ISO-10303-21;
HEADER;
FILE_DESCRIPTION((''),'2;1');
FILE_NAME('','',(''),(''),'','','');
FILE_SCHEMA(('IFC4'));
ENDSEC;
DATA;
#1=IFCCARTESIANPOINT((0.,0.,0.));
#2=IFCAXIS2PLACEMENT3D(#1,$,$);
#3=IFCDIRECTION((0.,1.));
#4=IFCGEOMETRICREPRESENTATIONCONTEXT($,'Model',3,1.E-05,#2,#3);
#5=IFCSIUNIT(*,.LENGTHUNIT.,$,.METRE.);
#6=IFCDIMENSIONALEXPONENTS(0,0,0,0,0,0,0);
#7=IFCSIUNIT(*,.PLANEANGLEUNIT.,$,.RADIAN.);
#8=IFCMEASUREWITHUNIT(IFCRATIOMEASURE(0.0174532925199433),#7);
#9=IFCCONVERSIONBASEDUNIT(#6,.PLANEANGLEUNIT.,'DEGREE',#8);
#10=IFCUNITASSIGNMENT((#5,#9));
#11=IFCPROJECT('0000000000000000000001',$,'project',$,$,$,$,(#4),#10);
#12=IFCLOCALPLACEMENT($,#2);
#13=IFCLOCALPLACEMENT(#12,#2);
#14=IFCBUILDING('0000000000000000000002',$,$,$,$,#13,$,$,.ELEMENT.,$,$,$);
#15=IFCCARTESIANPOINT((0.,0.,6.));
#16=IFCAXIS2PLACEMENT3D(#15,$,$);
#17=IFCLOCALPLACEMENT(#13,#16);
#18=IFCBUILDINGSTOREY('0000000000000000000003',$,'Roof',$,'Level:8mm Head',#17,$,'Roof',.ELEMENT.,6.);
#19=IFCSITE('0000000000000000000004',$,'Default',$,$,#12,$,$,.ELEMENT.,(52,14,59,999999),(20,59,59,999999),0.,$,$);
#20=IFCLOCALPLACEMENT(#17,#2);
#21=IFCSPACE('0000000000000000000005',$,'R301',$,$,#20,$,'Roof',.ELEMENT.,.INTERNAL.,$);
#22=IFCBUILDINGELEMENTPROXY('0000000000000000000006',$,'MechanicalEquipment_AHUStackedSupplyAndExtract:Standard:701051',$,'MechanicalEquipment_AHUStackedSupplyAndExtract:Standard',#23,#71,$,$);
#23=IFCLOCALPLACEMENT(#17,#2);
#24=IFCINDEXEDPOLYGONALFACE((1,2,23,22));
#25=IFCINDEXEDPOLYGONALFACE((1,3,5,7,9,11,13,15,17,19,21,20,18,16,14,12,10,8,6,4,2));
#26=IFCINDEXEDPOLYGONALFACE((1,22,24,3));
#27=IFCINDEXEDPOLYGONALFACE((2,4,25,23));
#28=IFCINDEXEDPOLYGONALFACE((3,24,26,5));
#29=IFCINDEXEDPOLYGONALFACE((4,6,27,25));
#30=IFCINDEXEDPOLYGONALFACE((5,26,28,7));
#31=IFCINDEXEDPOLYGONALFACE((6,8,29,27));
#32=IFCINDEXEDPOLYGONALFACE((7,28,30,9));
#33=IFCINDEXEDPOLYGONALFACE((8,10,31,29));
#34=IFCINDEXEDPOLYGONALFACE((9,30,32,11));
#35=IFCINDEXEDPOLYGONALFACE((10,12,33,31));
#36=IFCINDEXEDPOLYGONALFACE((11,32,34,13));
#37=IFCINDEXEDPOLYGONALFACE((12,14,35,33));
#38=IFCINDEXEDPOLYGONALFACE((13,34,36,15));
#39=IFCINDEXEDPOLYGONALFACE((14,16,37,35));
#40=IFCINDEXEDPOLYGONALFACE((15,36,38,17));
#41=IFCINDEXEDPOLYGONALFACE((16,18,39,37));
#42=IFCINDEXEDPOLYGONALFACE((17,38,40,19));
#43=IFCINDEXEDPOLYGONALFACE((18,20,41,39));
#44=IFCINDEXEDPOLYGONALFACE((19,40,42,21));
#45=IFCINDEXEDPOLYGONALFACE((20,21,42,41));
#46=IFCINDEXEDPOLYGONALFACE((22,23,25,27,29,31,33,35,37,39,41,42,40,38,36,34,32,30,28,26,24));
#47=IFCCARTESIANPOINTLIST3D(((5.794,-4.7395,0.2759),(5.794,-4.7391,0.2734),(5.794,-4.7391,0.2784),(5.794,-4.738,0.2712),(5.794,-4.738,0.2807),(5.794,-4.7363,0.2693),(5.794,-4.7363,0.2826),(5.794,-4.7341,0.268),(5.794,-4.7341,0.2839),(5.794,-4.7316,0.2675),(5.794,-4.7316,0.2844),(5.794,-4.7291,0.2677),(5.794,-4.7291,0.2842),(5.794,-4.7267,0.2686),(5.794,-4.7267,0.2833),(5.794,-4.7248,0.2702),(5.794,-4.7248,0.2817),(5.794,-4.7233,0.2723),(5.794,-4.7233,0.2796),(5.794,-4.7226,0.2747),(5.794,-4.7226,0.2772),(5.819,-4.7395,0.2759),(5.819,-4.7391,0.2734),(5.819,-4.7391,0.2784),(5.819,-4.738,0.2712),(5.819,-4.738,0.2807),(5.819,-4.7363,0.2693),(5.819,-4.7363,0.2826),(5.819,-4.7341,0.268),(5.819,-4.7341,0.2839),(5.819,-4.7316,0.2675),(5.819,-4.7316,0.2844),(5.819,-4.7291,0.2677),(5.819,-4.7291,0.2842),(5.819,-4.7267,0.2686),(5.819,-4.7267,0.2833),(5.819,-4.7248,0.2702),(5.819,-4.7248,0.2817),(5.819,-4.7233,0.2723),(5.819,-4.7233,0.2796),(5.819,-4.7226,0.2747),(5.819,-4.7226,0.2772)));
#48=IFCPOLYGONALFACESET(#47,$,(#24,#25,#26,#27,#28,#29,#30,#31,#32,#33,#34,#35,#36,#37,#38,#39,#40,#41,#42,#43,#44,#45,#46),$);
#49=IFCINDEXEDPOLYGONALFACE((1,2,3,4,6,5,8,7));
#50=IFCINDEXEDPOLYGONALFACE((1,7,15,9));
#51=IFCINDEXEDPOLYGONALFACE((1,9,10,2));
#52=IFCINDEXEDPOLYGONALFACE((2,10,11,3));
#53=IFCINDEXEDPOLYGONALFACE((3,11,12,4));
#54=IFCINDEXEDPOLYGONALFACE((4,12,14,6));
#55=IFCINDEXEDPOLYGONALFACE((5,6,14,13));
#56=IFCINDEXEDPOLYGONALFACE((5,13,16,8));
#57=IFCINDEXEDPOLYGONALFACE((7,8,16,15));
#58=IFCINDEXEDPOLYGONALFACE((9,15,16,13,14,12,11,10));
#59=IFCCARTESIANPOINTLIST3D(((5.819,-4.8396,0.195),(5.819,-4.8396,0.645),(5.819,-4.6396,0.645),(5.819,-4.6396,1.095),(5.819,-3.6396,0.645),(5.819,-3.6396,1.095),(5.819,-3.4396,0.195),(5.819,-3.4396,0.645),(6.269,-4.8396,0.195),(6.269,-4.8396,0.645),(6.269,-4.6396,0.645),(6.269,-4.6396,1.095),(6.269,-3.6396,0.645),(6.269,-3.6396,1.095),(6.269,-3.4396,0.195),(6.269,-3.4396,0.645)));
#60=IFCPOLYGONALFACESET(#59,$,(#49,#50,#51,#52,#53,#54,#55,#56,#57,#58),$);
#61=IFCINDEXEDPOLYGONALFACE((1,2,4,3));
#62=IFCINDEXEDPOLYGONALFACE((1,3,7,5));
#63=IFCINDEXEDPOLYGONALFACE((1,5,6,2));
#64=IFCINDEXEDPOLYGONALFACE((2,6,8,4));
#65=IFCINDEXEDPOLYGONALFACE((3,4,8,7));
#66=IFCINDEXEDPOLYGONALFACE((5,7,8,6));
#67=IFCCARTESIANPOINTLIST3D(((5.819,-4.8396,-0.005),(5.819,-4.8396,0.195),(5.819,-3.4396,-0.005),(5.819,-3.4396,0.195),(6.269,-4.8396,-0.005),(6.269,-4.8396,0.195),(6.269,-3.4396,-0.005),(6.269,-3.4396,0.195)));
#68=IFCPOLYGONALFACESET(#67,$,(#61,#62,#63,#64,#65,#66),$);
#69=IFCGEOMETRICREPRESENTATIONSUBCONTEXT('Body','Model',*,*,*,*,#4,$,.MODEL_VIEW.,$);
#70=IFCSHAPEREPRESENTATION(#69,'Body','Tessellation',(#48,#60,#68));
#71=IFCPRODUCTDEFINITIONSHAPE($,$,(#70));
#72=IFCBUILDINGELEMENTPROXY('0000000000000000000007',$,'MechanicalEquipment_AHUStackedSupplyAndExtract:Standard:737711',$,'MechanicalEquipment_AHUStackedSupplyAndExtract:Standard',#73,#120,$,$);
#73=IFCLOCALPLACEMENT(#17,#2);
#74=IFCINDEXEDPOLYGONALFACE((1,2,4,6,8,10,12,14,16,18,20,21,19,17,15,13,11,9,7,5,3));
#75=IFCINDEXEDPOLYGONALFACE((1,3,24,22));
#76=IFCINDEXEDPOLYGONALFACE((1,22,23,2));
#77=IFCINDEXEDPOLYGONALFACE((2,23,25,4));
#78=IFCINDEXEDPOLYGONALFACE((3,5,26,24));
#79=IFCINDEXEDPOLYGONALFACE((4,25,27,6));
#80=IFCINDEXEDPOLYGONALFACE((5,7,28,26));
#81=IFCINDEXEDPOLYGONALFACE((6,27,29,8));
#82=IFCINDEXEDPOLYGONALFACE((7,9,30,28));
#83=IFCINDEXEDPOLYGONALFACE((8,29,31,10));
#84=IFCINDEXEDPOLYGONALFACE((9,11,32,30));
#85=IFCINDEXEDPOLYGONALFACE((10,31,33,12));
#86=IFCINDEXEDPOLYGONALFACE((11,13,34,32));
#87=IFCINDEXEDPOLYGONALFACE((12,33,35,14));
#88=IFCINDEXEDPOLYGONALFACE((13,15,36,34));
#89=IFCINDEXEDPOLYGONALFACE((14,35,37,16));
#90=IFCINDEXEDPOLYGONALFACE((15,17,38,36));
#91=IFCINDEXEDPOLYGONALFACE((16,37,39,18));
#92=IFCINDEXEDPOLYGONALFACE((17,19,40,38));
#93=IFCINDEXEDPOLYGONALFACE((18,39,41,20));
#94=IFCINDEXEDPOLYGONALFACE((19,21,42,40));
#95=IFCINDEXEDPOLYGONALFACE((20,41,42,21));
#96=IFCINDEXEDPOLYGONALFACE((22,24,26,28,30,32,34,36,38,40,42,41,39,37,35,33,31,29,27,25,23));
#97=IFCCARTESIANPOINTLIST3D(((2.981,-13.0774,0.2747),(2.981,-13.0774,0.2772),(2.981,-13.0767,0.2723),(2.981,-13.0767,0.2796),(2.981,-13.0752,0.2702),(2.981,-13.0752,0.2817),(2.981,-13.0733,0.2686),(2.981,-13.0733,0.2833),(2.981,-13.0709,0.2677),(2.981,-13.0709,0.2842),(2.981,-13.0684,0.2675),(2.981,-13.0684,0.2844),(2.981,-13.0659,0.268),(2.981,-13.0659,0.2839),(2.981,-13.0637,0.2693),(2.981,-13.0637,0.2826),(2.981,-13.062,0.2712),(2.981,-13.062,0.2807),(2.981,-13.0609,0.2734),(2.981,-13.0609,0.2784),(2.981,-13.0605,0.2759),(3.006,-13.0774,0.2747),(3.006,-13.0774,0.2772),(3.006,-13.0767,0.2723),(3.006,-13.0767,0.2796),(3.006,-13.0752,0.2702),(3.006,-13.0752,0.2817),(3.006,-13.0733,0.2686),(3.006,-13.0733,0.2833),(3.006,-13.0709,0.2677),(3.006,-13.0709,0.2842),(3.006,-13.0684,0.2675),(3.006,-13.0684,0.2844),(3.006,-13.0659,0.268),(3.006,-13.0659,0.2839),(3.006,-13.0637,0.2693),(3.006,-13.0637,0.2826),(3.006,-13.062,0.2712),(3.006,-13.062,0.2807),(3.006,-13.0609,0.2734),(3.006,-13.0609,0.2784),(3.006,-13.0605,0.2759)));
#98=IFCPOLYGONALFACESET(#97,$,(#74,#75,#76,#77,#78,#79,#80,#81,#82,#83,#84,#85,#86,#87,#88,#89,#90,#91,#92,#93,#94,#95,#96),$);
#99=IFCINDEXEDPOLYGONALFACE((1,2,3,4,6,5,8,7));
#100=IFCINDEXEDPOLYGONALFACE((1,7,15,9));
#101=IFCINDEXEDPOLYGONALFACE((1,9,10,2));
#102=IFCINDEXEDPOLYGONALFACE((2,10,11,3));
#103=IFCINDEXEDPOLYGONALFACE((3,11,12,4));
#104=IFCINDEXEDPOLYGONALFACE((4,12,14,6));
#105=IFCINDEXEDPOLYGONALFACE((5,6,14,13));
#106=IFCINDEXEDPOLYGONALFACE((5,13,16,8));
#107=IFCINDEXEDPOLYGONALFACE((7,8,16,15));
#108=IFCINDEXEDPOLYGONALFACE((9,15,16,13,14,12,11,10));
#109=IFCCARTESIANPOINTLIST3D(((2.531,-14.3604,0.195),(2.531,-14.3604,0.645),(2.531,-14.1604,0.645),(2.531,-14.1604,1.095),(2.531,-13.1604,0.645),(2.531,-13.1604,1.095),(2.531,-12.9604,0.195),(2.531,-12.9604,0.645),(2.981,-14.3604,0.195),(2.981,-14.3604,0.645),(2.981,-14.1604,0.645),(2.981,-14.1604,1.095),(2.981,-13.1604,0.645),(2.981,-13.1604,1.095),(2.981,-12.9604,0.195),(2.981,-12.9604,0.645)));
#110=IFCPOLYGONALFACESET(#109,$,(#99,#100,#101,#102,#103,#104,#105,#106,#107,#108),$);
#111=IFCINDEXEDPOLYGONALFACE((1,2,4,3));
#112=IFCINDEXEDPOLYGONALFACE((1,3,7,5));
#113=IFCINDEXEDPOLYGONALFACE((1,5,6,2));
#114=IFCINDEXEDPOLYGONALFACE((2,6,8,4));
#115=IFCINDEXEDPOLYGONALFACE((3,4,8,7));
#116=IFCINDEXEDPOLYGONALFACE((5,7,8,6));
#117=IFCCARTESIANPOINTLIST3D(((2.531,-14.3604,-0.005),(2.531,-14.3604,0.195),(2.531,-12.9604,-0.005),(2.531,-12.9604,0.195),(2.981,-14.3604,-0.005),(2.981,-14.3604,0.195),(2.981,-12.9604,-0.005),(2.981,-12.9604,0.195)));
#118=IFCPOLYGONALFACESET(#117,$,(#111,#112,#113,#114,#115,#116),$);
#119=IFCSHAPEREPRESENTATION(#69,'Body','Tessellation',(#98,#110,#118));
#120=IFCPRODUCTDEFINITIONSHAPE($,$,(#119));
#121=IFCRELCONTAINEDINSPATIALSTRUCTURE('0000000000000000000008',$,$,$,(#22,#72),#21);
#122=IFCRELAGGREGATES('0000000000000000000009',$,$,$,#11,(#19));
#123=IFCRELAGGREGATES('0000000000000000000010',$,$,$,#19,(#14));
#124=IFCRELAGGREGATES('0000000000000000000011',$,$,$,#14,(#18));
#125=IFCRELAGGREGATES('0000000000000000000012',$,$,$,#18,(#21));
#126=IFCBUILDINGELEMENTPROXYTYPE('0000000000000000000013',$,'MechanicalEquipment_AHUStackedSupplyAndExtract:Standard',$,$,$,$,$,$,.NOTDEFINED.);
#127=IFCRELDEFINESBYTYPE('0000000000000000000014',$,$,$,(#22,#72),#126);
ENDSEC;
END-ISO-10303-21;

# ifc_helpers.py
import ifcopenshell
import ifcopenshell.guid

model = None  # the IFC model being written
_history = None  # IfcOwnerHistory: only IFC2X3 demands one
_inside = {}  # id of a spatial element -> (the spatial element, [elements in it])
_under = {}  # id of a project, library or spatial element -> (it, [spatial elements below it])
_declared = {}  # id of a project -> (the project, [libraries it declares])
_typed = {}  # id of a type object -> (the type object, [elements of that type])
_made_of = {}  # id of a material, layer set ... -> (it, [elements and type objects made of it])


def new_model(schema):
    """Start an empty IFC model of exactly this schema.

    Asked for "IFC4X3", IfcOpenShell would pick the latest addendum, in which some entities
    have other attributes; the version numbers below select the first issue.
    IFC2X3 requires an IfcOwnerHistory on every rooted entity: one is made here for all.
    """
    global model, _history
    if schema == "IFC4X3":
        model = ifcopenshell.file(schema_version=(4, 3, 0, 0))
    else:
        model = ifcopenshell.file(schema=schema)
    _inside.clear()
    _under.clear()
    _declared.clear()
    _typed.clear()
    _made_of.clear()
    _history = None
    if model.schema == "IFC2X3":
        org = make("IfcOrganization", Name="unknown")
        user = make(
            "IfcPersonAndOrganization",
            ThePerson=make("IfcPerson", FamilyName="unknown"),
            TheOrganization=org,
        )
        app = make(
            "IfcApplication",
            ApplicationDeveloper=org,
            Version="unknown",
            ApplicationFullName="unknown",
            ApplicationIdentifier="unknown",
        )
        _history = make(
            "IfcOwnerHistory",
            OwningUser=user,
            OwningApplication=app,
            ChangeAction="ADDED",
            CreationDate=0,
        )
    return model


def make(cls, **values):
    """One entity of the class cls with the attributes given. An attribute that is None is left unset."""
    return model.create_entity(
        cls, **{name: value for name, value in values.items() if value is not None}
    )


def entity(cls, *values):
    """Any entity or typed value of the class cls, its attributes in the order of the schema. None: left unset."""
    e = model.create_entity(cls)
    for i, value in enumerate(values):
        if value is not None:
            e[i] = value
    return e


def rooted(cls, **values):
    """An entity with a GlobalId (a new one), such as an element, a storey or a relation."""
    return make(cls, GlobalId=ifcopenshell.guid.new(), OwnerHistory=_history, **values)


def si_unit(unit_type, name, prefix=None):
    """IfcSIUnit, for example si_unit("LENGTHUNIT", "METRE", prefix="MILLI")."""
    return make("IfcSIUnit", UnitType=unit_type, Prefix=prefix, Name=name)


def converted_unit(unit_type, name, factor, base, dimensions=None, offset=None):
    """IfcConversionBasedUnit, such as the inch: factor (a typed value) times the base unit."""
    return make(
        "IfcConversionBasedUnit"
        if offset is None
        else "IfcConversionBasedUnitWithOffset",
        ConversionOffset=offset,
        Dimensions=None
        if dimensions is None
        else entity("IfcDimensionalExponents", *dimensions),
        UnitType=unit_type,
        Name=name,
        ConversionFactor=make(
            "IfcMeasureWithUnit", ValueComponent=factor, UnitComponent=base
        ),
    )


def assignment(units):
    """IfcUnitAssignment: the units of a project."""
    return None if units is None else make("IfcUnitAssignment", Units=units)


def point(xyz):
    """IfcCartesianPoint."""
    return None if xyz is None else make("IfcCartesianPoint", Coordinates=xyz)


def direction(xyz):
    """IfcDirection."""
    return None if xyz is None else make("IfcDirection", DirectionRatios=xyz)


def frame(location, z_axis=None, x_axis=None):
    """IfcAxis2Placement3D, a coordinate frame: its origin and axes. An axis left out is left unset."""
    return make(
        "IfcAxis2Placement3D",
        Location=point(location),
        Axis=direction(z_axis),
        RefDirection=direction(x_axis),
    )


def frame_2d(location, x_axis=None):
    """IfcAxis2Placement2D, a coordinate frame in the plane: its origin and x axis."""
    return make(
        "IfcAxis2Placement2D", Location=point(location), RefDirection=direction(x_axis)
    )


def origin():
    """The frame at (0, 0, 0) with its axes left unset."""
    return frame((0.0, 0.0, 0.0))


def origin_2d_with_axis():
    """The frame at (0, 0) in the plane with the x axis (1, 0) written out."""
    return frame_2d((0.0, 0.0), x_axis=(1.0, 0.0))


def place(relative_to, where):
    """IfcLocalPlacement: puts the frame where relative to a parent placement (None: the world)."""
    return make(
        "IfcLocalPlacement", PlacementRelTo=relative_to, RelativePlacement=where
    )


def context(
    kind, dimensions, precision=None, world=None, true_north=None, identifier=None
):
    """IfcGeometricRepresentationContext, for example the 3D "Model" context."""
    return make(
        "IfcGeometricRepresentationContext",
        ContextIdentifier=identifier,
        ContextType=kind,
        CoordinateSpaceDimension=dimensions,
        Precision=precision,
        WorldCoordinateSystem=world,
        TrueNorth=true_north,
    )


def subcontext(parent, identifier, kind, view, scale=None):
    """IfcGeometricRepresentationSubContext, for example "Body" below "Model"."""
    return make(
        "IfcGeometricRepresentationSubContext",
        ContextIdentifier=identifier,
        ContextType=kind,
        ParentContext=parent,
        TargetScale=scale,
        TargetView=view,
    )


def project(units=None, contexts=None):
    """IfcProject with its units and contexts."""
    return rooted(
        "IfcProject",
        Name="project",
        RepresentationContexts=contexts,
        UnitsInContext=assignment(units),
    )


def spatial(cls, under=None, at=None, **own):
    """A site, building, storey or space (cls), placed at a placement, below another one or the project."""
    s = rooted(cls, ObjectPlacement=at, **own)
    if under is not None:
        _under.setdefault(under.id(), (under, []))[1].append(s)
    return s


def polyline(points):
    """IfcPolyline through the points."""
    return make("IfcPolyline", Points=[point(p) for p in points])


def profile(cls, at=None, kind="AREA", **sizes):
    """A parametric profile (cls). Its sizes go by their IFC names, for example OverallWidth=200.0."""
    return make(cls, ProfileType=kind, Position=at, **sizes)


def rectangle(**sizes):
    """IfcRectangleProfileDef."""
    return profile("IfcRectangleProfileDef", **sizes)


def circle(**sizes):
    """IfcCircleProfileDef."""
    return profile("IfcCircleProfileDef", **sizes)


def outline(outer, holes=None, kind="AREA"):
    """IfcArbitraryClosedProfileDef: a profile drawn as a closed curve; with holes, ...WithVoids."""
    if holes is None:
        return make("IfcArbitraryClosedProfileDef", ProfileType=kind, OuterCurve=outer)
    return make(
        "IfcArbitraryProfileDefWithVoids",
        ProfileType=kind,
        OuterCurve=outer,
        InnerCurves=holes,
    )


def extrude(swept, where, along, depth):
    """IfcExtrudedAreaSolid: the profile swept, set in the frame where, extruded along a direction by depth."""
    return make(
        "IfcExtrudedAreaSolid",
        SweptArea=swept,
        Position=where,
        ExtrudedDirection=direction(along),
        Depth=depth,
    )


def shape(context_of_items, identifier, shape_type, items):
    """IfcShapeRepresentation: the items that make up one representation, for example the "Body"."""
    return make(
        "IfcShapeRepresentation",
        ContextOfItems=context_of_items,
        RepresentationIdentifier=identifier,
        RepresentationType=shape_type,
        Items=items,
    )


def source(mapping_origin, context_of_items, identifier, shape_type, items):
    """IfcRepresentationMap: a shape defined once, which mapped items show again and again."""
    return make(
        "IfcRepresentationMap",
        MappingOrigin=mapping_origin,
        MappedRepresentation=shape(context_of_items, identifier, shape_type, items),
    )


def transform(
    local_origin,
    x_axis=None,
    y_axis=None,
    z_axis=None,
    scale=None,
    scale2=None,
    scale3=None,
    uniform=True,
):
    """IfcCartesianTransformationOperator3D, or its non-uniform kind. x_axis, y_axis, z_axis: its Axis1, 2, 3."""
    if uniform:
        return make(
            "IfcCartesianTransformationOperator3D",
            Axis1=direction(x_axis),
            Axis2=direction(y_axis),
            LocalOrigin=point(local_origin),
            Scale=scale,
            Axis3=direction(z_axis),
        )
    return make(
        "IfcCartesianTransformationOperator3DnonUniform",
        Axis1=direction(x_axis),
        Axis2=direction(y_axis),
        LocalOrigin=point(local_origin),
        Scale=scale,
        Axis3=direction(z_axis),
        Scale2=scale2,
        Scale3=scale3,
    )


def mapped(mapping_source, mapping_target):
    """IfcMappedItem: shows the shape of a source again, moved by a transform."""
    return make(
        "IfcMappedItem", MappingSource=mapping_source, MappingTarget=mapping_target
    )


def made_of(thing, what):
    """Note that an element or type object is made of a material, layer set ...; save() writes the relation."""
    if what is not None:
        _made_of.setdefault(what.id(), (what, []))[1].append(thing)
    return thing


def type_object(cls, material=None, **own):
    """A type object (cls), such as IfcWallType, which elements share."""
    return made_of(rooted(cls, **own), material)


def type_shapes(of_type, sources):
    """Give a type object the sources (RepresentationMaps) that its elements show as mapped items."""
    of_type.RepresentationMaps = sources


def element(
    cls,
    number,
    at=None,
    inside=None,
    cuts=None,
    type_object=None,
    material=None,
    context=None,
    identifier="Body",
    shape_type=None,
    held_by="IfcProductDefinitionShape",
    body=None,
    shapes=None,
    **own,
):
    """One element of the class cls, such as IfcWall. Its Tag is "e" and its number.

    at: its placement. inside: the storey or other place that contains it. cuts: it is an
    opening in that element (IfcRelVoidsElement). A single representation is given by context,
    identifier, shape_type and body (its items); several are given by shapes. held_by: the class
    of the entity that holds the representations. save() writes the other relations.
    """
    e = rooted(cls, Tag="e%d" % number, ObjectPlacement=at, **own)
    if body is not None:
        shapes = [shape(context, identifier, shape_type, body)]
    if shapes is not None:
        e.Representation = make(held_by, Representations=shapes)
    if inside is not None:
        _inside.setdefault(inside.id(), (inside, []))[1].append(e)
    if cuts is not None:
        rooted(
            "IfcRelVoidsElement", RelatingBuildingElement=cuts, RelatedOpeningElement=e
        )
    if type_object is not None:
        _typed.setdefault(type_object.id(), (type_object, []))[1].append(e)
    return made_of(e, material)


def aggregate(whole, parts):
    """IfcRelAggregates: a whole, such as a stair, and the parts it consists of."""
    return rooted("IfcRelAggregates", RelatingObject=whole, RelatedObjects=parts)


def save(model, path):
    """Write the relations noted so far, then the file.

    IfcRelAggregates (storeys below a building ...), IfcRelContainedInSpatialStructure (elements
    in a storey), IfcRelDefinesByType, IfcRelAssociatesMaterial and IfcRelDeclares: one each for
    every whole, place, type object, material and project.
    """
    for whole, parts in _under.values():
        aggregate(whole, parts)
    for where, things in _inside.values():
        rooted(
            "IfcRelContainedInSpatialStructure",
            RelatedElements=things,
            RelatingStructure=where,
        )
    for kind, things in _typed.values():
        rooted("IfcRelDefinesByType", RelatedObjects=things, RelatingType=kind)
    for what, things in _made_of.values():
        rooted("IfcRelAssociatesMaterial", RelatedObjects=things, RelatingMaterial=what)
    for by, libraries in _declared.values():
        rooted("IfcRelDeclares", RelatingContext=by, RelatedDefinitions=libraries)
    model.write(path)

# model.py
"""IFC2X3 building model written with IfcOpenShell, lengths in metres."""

from ifc_helpers import new_model, entity, si_unit, converted_unit, direction, frame, frame_2d, origin, origin_2d_with_axis, place, context, subcontext, project, spatial, polyline, rectangle, circle, outline, extrude, source, transform, mapped, type_object, type_shapes, element, save


model = new_model("IFC2X3")

# Units and contexts
model_context = context("Model", 3, precision=1e-05, world=origin(), true_north=direction((0.0, 1.0)))
body_context = subcontext(model_context, "Body", "Model", "MODEL_VIEW")
ifc_project = project(units=[si_unit("LENGTHUNIT", "METRE"), converted_unit("PLANEANGLEUNIT", "DEGREE", entity("IfcRatioMeasure", 0.0174532925199433), si_unit("PLANEANGLEUNIT", "RADIAN"), dimensions=[0, 0, 0, 0, 0, 0, 0])], contexts=[model_context])

# Site, building, storey
site_placement = place(None, origin())
site = spatial("IfcSite", under=ifc_project, at=site_placement, Name="Default", CompositionType="ELEMENT", RefLatitude=(52, 14, 59, 999999), RefLongitude=(20, 59, 59, 999999), RefElevation=0.0)
building_placement = place(site_placement, origin())
building = spatial("IfcBuilding", under=site, at=building_placement, CompositionType="ELEMENT")
storey_placement = place(building_placement, frame((0.0, 0.0, 6.0)))
storey = spatial("IfcBuildingStorey", under=building, at=storey_placement, Name="Roof", ObjectType="Level:8mm Head", LongName="Roof", CompositionType="ELEMENT", Elevation=6.0)

# Shared definitions
space_placement = place(storey_placement, origin())
space = spatial("IfcSpace", under=storey, at=space_placement, Name="R301", LongName="Roof", CompositionType="ELEMENT", InteriorOrExteriorSpace="INTERNAL")

# Building element proxies
building_element_proxy_type = type_object("IfcBuildingElementProxyType", Name="MechanicalEquipment_AHUStackedSupplyAndExtract:Standard", PredefinedType="NOTDEFINED")
shared_shape_1 = source(origin(), body_context, "Body", "SweptSolid", [
    extrude(circle(Radius=0.0085, at=frame_2d((0.0, 0.0), x_axis=(1.0, 0.0))), frame((0.0763, -0.25, 0.0809), z_axis=(0.0, 1.0, 0.0), x_axis=(1.0, 0.0, 0.0)), (0.0, 0.0, 1.0), 0.025),
    extrude(outline(polyline([(-0.7, 0.0), (-0.7, -0.45), (0.7, -0.45), (0.7, 0.0), (0.5, 0.0), (0.5, 0.45), (-0.5, 0.45), (-0.5, 0.0), (-0.7, 0.0)])), frame((-0.515, -0.225, 0.45), z_axis=(0.0, -1.0, 0.0), x_axis=(1.0, 0.0, 0.0)), (0.0, 0.0, -1.0), 0.45),
    extrude(rectangle(XDim=0.45, YDim=1.4, at=origin_2d_with_axis()), frame((-0.515, 0.0, -0.2), z_axis=(0.0, 0.0, 1.0), x_axis=(0.0, 1.0, 0.0)), (0.0, 0.0, 1.0), 0.2),
])
type_shapes(building_element_proxy_type, [shared_shape_1])
for number, where, z_axis, x_axis, name in (
    (1, (6.044, -4.6546, 0.195), (0.0, 0.0, 1.0), (0.0, -1.0, 0.0), "MechanicalEquipment_AHUStackedSupplyAndExtract:Standard:701051"),
    (2, (2.756, -13.1454, 0.195), (0.0, 0.0, 1.0), (0.0, 1.0, 0.0), "MechanicalEquipment_AHUStackedSupplyAndExtract:Standard:737711"),
):
    element("IfcBuildingElementProxy", number, at=place(space_placement, frame(where, z_axis=z_axis, x_axis=x_axis)), inside=space, type_object=building_element_proxy_type, Name=name, ObjectType="MechanicalEquipment_AHUStackedSupplyAndExtract:Standard", context=body_context, shape_type="MappedRepresentation", body=[
        mapped(shared_shape_1, transform((0.0, 0.0, 0.0), scale=1.0)),
    ])

save(model, "model.ifc")
